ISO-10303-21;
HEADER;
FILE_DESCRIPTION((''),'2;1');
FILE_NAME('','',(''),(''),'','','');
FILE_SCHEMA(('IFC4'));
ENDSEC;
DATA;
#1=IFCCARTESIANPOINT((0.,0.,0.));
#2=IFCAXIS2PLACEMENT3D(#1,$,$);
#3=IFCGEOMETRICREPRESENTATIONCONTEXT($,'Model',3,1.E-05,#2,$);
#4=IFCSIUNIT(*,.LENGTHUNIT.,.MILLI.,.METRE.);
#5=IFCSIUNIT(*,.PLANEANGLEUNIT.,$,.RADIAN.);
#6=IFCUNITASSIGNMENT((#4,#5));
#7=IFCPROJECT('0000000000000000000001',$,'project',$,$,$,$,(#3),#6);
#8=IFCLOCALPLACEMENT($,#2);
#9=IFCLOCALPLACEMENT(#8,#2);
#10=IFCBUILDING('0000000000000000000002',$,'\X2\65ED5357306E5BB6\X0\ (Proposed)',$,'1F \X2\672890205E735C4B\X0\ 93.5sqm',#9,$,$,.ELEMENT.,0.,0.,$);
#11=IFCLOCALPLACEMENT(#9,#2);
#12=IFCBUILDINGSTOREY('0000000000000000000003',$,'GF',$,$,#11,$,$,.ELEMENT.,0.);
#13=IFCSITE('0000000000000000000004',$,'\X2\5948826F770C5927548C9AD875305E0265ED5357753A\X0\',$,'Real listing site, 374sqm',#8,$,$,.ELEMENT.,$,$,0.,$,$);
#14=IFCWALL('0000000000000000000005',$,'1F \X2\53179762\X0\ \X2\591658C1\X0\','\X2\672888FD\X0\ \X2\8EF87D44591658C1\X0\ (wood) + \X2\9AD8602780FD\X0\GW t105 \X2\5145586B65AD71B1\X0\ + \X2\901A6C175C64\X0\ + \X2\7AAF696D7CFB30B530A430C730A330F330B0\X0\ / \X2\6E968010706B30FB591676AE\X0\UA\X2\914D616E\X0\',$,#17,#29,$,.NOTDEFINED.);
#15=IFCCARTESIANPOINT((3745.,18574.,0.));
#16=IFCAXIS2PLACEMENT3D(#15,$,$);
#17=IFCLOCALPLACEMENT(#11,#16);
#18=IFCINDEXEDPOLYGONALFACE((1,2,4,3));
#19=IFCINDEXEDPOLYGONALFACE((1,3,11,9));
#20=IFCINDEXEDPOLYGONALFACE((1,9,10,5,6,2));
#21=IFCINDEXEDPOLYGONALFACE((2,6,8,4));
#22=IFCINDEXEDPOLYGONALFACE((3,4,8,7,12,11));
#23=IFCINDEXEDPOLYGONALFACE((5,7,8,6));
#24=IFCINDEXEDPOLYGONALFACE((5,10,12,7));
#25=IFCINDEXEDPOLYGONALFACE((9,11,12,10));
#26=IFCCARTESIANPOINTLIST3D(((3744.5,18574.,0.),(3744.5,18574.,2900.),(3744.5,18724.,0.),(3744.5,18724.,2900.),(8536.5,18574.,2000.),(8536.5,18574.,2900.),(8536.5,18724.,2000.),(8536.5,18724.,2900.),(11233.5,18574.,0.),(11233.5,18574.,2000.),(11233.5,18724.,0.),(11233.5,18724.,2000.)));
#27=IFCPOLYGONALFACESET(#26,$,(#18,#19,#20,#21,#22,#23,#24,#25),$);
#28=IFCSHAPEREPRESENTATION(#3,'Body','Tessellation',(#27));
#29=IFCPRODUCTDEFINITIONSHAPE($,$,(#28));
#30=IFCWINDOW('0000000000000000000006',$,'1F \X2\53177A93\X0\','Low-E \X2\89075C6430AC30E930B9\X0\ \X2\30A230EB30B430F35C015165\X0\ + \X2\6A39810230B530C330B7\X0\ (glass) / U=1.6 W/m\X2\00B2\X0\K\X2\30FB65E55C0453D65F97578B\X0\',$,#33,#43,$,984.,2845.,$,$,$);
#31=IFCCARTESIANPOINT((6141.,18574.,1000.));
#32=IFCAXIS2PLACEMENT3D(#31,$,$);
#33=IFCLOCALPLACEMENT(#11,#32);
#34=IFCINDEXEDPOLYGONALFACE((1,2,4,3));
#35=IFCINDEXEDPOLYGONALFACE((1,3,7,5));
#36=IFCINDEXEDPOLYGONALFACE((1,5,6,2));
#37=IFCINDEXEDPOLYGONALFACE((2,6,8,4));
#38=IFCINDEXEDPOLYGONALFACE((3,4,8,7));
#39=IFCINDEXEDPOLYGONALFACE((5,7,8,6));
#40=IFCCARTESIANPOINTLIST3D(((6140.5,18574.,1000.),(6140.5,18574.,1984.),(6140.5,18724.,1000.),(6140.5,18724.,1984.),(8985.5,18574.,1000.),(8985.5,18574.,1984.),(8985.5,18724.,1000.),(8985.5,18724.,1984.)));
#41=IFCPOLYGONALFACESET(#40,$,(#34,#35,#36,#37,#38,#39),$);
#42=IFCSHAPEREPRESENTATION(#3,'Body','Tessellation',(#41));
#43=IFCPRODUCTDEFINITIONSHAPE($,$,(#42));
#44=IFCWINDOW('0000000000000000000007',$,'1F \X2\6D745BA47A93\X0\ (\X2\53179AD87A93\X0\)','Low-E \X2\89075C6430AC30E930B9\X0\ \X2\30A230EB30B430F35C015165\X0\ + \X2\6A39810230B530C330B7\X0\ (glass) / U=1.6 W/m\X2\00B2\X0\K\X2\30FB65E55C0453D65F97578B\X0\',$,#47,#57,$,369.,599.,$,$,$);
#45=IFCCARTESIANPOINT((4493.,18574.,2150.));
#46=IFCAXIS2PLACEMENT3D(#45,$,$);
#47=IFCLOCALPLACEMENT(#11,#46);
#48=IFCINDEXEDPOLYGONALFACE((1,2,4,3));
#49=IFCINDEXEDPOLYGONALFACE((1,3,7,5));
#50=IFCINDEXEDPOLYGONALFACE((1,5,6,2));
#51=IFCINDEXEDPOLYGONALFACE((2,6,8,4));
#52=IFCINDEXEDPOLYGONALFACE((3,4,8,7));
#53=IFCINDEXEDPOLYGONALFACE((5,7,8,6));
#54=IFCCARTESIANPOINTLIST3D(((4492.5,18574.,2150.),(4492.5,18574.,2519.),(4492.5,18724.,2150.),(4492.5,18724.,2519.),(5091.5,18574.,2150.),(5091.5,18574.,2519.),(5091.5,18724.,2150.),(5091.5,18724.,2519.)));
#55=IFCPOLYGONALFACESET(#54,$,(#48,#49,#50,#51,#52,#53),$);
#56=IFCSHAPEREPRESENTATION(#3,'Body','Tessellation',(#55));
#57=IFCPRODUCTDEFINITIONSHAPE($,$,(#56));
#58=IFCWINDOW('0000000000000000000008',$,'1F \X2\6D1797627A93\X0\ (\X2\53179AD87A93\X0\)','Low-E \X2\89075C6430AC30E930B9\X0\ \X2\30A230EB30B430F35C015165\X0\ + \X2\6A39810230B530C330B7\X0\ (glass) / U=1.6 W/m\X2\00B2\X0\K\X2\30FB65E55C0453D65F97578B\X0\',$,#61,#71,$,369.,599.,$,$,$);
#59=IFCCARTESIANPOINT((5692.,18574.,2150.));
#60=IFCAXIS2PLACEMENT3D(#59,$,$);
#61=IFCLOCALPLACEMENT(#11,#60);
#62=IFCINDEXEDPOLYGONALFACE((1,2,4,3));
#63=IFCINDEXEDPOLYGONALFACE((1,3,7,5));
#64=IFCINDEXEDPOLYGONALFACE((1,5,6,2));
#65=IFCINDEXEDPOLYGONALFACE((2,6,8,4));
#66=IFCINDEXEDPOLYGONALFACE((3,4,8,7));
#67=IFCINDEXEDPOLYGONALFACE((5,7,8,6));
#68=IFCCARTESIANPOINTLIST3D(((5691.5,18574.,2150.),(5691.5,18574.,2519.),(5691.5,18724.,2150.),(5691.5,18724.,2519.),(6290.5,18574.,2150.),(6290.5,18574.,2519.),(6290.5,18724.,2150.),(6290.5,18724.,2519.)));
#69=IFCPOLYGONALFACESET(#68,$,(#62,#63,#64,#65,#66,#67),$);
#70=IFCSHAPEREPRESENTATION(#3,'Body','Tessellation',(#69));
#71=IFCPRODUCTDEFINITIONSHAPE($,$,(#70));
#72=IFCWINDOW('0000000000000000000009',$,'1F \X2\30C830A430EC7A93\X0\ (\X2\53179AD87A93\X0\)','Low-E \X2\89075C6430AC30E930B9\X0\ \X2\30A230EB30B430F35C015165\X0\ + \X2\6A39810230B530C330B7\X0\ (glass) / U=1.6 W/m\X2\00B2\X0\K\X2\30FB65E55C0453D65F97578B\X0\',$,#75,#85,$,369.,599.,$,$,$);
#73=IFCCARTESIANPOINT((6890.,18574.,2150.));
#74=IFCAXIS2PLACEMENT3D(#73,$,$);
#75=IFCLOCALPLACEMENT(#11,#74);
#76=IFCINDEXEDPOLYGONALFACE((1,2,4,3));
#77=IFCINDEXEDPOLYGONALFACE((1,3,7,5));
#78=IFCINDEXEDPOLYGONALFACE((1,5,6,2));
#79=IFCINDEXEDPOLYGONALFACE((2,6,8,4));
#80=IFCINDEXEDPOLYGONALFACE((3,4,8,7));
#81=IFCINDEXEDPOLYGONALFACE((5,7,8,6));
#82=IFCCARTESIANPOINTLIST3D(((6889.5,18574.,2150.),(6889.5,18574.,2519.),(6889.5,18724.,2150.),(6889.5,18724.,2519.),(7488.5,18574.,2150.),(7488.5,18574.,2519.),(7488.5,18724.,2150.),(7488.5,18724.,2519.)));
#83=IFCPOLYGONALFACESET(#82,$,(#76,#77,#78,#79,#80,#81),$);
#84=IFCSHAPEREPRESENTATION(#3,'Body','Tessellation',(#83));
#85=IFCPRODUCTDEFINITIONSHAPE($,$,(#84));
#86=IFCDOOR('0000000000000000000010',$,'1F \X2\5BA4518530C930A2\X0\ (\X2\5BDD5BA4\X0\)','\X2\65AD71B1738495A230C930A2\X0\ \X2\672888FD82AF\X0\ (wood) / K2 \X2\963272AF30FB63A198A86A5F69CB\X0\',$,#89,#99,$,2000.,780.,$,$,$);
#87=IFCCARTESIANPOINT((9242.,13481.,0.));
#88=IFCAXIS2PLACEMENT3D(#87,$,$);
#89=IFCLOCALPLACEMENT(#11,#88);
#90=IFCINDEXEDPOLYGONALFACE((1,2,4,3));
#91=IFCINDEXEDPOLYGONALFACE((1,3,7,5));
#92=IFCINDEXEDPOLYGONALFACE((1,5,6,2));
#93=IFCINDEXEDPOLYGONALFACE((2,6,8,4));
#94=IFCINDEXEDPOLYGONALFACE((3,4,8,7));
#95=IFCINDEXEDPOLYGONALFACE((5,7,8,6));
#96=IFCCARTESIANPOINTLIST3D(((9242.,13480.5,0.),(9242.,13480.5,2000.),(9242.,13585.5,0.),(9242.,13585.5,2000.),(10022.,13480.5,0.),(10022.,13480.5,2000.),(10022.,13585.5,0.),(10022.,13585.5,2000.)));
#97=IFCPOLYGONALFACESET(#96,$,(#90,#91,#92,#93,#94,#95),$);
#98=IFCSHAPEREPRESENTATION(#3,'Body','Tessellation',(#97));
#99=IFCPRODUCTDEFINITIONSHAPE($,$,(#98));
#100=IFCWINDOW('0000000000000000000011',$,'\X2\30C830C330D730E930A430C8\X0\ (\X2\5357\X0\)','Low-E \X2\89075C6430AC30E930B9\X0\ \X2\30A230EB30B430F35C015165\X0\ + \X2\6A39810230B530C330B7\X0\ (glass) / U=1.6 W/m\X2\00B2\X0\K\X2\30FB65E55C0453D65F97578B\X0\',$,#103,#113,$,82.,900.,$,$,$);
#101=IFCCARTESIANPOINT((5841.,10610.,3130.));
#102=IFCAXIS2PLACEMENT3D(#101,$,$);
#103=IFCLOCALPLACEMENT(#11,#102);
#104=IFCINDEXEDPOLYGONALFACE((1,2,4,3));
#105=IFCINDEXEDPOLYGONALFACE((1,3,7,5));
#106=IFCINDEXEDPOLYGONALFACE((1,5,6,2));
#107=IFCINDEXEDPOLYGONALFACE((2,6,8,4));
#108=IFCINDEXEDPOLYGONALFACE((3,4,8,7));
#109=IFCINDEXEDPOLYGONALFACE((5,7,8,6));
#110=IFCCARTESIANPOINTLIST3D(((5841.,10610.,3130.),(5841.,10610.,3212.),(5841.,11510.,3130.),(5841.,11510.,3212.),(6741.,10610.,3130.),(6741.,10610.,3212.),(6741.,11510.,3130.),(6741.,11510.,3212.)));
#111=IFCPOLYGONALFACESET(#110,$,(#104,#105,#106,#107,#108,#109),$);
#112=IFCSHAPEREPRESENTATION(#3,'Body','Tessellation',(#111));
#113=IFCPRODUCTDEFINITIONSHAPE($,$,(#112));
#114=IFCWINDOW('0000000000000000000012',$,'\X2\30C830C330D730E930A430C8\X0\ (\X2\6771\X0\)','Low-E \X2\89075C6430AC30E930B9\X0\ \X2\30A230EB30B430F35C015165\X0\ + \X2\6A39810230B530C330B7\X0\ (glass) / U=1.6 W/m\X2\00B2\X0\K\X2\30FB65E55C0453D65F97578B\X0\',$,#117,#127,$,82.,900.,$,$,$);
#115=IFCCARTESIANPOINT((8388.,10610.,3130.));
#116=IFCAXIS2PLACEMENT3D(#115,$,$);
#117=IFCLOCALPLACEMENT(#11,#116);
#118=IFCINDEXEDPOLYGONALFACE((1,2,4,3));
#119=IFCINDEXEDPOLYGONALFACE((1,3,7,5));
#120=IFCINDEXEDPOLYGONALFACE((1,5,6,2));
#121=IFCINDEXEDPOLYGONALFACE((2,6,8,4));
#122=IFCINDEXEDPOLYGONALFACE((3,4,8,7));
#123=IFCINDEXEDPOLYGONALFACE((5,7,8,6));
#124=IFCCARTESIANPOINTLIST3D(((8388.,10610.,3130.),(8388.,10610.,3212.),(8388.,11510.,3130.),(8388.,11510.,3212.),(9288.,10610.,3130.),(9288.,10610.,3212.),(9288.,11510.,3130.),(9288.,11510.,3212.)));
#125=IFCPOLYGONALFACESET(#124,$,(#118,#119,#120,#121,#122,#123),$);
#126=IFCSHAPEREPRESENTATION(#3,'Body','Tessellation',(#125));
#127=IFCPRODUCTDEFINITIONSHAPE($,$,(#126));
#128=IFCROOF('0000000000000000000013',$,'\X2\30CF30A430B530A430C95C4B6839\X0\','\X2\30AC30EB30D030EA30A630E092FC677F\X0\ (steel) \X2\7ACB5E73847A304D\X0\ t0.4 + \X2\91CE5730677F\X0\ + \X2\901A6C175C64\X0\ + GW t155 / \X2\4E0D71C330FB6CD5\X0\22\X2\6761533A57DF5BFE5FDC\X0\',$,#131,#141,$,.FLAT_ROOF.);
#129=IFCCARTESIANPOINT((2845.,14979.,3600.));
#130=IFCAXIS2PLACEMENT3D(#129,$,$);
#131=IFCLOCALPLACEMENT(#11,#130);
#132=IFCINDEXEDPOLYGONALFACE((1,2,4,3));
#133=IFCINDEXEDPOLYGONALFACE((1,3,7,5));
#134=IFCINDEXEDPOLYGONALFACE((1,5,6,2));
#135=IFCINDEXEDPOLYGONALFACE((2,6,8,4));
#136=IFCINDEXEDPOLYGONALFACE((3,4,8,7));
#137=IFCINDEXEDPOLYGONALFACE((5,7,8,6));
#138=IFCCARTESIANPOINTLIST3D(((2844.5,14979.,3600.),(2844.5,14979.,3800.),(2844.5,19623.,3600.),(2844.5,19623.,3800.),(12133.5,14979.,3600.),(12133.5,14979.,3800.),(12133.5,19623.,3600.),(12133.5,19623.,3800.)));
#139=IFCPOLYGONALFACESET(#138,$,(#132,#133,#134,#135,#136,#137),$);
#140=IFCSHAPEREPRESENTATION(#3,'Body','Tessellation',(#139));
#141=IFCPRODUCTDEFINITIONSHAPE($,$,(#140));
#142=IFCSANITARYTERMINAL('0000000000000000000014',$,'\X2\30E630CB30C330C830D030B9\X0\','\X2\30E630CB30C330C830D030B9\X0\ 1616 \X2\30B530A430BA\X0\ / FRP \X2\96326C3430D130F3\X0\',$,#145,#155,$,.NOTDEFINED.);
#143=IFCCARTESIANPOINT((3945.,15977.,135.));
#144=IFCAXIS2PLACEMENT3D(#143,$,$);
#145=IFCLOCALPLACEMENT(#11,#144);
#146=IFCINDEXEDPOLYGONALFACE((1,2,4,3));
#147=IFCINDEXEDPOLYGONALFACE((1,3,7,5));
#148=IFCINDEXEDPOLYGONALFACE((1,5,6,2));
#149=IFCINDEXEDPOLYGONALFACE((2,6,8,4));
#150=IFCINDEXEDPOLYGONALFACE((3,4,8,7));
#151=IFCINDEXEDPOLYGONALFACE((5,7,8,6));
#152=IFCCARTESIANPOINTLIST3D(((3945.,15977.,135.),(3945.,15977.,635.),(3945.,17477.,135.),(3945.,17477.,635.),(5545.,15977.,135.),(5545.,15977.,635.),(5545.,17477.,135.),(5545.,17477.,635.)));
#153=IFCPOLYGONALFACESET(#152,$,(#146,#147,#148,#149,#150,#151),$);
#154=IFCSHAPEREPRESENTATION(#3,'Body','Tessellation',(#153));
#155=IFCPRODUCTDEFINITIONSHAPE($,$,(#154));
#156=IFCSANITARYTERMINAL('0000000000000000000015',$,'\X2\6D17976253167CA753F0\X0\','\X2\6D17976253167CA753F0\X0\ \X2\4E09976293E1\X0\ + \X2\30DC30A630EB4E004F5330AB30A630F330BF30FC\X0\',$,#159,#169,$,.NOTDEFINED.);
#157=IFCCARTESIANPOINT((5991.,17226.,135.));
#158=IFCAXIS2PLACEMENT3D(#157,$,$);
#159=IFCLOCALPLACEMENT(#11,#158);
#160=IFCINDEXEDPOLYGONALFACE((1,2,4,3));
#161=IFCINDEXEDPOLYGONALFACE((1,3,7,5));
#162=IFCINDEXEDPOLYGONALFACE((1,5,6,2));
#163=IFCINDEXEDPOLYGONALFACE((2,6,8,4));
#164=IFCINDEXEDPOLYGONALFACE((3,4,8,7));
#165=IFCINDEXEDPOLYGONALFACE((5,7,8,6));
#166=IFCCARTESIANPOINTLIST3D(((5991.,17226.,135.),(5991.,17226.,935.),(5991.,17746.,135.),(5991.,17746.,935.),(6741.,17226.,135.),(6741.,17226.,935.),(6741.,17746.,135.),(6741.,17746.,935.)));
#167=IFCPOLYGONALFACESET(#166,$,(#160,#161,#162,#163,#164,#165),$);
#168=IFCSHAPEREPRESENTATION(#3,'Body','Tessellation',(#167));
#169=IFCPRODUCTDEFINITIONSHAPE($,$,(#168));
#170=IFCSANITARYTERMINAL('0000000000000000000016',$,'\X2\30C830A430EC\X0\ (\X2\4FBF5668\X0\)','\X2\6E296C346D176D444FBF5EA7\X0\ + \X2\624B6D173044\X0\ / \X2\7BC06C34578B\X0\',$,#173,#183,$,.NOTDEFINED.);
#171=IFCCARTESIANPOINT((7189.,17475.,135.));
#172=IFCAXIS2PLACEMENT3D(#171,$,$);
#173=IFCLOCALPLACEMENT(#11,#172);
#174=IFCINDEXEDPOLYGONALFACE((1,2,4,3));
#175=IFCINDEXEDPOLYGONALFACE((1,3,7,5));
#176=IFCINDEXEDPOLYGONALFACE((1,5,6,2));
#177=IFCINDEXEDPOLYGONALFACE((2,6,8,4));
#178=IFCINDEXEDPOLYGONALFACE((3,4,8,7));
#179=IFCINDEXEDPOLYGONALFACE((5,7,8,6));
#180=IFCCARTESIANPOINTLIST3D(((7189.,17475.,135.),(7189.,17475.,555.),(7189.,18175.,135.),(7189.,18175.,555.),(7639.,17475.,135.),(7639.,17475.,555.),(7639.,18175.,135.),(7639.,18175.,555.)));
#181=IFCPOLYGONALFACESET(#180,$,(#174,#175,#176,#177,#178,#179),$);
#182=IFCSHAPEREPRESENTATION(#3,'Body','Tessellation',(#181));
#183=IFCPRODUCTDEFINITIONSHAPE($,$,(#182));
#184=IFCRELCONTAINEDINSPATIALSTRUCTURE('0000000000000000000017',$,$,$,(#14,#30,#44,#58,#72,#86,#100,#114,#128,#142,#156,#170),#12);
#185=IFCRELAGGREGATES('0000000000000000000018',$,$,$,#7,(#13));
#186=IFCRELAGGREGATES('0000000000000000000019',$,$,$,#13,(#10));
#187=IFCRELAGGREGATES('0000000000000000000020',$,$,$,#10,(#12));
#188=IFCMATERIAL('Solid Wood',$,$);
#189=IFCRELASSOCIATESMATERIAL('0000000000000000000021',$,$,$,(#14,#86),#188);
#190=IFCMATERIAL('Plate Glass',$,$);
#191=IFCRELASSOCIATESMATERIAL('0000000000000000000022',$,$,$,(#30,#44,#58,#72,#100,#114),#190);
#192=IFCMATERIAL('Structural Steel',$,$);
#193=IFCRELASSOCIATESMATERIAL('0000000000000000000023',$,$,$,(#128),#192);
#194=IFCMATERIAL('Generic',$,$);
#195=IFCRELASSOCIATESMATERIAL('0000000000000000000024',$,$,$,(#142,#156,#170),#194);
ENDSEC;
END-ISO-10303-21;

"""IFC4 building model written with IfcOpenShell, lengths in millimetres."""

from ifc_helpers import new_model, si_unit, frame, frame_2d, origin, place, context, project, spatial, rectangle, extrude, material, element, fill, save


model = new_model("IFC4")

# Units and contexts
model_context = context("Model", 3, precision=1e-05, world=origin())
ifc_project = project(units=[si_unit("LENGTHUNIT", "METRE", prefix="MILLI"), si_unit("PLANEANGLEUNIT", "RADIAN")], contexts=[model_context])

# Site, building, storey
site_placement = place(None, origin())
site = spatial("IfcSite", under=ifc_project, at=site_placement, Name="奈良県大和高田市旭南町", ObjectType="Real listing site, 374sqm", CompositionType="ELEMENT", RefElevation=0.0)
building_placement = place(site_placement, origin())
building = spatial("IfcBuilding", under=site, at=building_placement, Name="旭南の家 (Proposed)", ObjectType="1F 木造平屋 93.5sqm", CompositionType="ELEMENT", ElevationOfRefHeight=0.0, ElevationOfTerrain=0.0)
storey_placement = place(building_placement, origin())
storey = spatial("IfcBuildingStorey", under=building, at=storey_placement, Name="GF", CompositionType="ELEMENT", Elevation=0.0)

# Shared definitions
ifc_material_1 = material(Name="Solid Wood")

# Wall, openings, windows
wall_1_placement = place(storey_placement, frame((3745.0, 18574.0, 0.0)))
wall_1 = element("IfcWall", 1, at=wall_1_placement, inside=storey, material=ifc_material_1, Name="1F 北面 外壁", Description="木製 軸組外壁 (wood) + 高性能GW t105 充填断熱 + 通気層 + 窯業系サイディング / 準耐火・外皮UA配慮", PredefinedType="NOTDEFINED", context=model_context, shape_type="SweptSolid", body=[
    extrude(rectangle(XDim=7489.0, YDim=150.0, at=frame_2d((3744.0, 75.0))), frame((3745.0, 18574.0, 0.0)), (0.0, 0.0, 1.0), 2900.0),
])
opening_1_placement = place(storey_placement, frame((6141.0, 18574.0, 1000.0)))
opening_1 = element("IfcOpeningElement", 2, at=opening_1_placement, cuts=wall_1, PredefinedType="NOTDEFINED", context=model_context, shape_type="SweptSolid", body=[
    extrude(rectangle(XDim=2845.0, YDim=150.0, at=frame_2d((1422.0, 75.0))), frame((6141.0, 18574.0, 1000.0)), (0.0, 0.0, 1.0), 984.0),
])
opening_2_placement = place(storey_placement, frame((4493.0, 18574.0, 2150.0)))
opening_2 = element("IfcOpeningElement", 3, at=opening_2_placement, cuts=wall_1, PredefinedType="NOTDEFINED", context=model_context, shape_type="SweptSolid", body=[
    extrude(rectangle(XDim=599.0, YDim=150.0, at=frame_2d((299.0, 75.0))), frame((4493.0, 18574.0, 2150.0)), (0.0, 0.0, 1.0), 369.0),
])
opening_3_placement = place(storey_placement, frame((5692.0, 18574.0, 2150.0)))
opening_3 = element("IfcOpeningElement", 4, at=opening_3_placement, cuts=wall_1, PredefinedType="NOTDEFINED", context=model_context, shape_type="SweptSolid", body=[
    extrude(rectangle(XDim=599.0, YDim=150.0, at=frame_2d((299.0, 75.0))), frame((5692.0, 18574.0, 2150.0)), (0.0, 0.0, 1.0), 369.0),
])
opening_4_placement = place(storey_placement, frame((6890.0, 18574.0, 2150.0)))
opening_4 = element("IfcOpeningElement", 5, at=opening_4_placement, cuts=wall_1, PredefinedType="NOTDEFINED", context=model_context, shape_type="SweptSolid", body=[
    extrude(rectangle(XDim=599.0, YDim=150.0, at=frame_2d((299.0, 75.0))), frame((6890.0, 18574.0, 2150.0)), (0.0, 0.0, 1.0), 369.0),
])
ifc_material_2 = material(Name="Plate Glass")
window_1_placement = place(storey_placement, frame((6141.0, 18574.0, 1000.0)))
window_1 = element("IfcWindow", 6, at=window_1_placement, inside=storey, material=ifc_material_2, Name="1F 北窓", Description="Low-E 複層ガラス アルゴン封入 + 樹脂サッシ (glass) / U=1.6 W/m²K・日射取得型", OverallHeight=984.0, OverallWidth=2845.0, context=model_context, shape_type="SweptSolid", body=[
    extrude(rectangle(XDim=2845.0, YDim=150.0, at=frame_2d((1422.0, 75.0))), frame((6141.0, 18574.0, 1000.0)), (0.0, 0.0, 1.0), 984.0),
])
fill(opening_1, window_1)
window_2_placement = place(storey_placement, frame((4493.0, 18574.0, 2150.0)))
window_2 = element("IfcWindow", 7, at=window_2_placement, inside=storey, material=ifc_material_2, Name="1F 浴室窓 (北高窓)", Description="Low-E 複層ガラス アルゴン封入 + 樹脂サッシ (glass) / U=1.6 W/m²K・日射取得型", OverallHeight=369.0, OverallWidth=599.0, context=model_context, shape_type="SweptSolid", body=[
    extrude(rectangle(XDim=599.0, YDim=150.0, at=frame_2d((299.0, 75.0))), frame((4493.0, 18574.0, 2150.0)), (0.0, 0.0, 1.0), 369.0),
])
fill(opening_2, window_2)
window_3_placement = place(storey_placement, frame((5692.0, 18574.0, 2150.0)))
window_3 = element("IfcWindow", 8, at=window_3_placement, inside=storey, material=ifc_material_2, Name="1F 洗面窓 (北高窓)", Description="Low-E 複層ガラス アルゴン封入 + 樹脂サッシ (glass) / U=1.6 W/m²K・日射取得型", OverallHeight=369.0, OverallWidth=599.0, context=model_context, shape_type="SweptSolid", body=[
    extrude(rectangle(XDim=599.0, YDim=150.0, at=frame_2d((299.0, 75.0))), frame((5692.0, 18574.0, 2150.0)), (0.0, 0.0, 1.0), 369.0),
])
fill(opening_3, window_3)
window_4_placement = place(storey_placement, frame((6890.0, 18574.0, 2150.0)))
window_4 = element("IfcWindow", 9, at=window_4_placement, inside=storey, material=ifc_material_2, Name="1F トイレ窓 (北高窓)", Description="Low-E 複層ガラス アルゴン封入 + 樹脂サッシ (glass) / U=1.6 W/m²K・日射取得型", OverallHeight=369.0, OverallWidth=599.0, context=model_context, shape_type="SweptSolid", body=[
    extrude(rectangle(XDim=599.0, YDim=150.0, at=frame_2d((299.0, 75.0))), frame((6890.0, 18574.0, 2150.0)), (0.0, 0.0, 1.0), 369.0),
])
fill(opening_4, window_4)

# Door
door_1_placement = place(storey_placement, frame((9242.0, 13481.0, 0.0)))
element("IfcDoor", 10, at=door_1_placement, inside=storey, material=ifc_material_1, Name="1F 室内ドア (寝室)", Description="断熱玄関ドア 木製芯 (wood) / K2 防犯・採風機構", OverallHeight=2000.0, OverallWidth=780.0, context=model_context, shape_type="SweptSolid", body=[
    extrude(rectangle(XDim=780.0, YDim=105.0, at=frame_2d((390.0, 52.0))), frame((9242.0, 13481.0, 0.0)), (0.0, 0.0, 1.0), 2000.0),
])

# Windows
window_5_placement = place(storey_placement, frame((5841.0, 10610.0, 3130.0)))
element("IfcWindow", 11, at=window_5_placement, inside=storey, material=ifc_material_2, Name="トップライト (南)", Description="Low-E 複層ガラス アルゴン封入 + 樹脂サッシ (glass) / U=1.6 W/m²K・日射取得型", OverallHeight=82.0, OverallWidth=900.0, context=model_context, shape_type="SweptSolid", body=[
    extrude(rectangle(XDim=900.0, YDim=900.0, at=frame_2d((450.0, 450.0))), frame((5841.0, 10610.0, 3130.0)), (0.0, 0.0, 1.0), 82.0),
])
window_6_placement = place(storey_placement, frame((8388.0, 10610.0, 3130.0)))
element("IfcWindow", 12, at=window_6_placement, inside=storey, material=ifc_material_2, Name="トップライト (東)", Description="Low-E 複層ガラス アルゴン封入 + 樹脂サッシ (glass) / U=1.6 W/m²K・日射取得型", OverallHeight=82.0, OverallWidth=900.0, context=model_context, shape_type="SweptSolid", body=[
    extrude(rectangle(XDim=900.0, YDim=900.0, at=frame_2d((450.0, 450.0))), frame((8388.0, 10610.0, 3130.0)), (0.0, 0.0, 1.0), 82.0),
])

# Roof
ifc_material_3 = material(Name="Structural Steel")
roof_placement = place(storey_placement, frame((2845.0, 14979.0, 3600.0)))
element("IfcRoof", 13, at=roof_placement, inside=storey, material=ifc_material_3, Name="ハイサイド屋根", Description="ガルバリウム鋼板 (steel) 立平葺き t0.4 + 野地板 + 通気層 + GW t155 / 不燃・法22条区域対応", PredefinedType="FLAT_ROOF", context=model_context, shape_type="SweptSolid", body=[
    extrude(rectangle(XDim=9289.0, YDim=4644.0, at=frame_2d((4644.0, 2322.0))), frame((2845.0, 14979.0, 3600.0)), (0.0, 0.0, 1.0), 200.0),
])

# Sanitary terminals
ifc_material_4 = material(Name="Generic")
sanitary_terminal_1_placement = place(storey_placement, frame((3945.0, 15977.0, 135.0)))
element("IfcSanitaryTerminal", 14, at=sanitary_terminal_1_placement, inside=storey, material=ifc_material_4, Name="ユニットバス", Description="ユニットバス 1616 サイズ / FRP 防水パン", PredefinedType="NOTDEFINED", context=model_context, shape_type="SweptSolid", body=[
    extrude(rectangle(XDim=1600.0, YDim=1500.0, at=frame_2d((800.0, 750.0))), frame((3945.0, 15977.0, 135.0)), (0.0, 0.0, 1.0), 500.0),
])
sanitary_terminal_2_placement = place(storey_placement, frame((5991.0, 17226.0, 135.0)))
element("IfcSanitaryTerminal", 15, at=sanitary_terminal_2_placement, inside=storey, material=ifc_material_4, Name="洗面化粧台", Description="洗面化粧台 三面鏡 + ボウル一体カウンター", PredefinedType="NOTDEFINED", context=model_context, shape_type="SweptSolid", body=[
    extrude(rectangle(XDim=750.0, YDim=520.0, at=frame_2d((375.0, 260.0))), frame((5991.0, 17226.0, 135.0)), (0.0, 0.0, 1.0), 800.0),
])
sanitary_terminal_3_placement = place(storey_placement, frame((7189.0, 17475.0, 135.0)))
element("IfcSanitaryTerminal", 16, at=sanitary_terminal_3_placement, inside=storey, material=ifc_material_4, Name="トイレ (便器)", Description="温水洗浄便座 + 手洗い / 節水型", PredefinedType="NOTDEFINED", context=model_context, shape_type="SweptSolid", body=[
    extrude(rectangle(XDim=450.0, YDim=700.0, at=frame_2d((225.0, 350.0))), frame((7189.0, 17475.0, 135.0)), (0.0, 0.0, 1.0), 420.0),
])

save(model, "model.ifc")
